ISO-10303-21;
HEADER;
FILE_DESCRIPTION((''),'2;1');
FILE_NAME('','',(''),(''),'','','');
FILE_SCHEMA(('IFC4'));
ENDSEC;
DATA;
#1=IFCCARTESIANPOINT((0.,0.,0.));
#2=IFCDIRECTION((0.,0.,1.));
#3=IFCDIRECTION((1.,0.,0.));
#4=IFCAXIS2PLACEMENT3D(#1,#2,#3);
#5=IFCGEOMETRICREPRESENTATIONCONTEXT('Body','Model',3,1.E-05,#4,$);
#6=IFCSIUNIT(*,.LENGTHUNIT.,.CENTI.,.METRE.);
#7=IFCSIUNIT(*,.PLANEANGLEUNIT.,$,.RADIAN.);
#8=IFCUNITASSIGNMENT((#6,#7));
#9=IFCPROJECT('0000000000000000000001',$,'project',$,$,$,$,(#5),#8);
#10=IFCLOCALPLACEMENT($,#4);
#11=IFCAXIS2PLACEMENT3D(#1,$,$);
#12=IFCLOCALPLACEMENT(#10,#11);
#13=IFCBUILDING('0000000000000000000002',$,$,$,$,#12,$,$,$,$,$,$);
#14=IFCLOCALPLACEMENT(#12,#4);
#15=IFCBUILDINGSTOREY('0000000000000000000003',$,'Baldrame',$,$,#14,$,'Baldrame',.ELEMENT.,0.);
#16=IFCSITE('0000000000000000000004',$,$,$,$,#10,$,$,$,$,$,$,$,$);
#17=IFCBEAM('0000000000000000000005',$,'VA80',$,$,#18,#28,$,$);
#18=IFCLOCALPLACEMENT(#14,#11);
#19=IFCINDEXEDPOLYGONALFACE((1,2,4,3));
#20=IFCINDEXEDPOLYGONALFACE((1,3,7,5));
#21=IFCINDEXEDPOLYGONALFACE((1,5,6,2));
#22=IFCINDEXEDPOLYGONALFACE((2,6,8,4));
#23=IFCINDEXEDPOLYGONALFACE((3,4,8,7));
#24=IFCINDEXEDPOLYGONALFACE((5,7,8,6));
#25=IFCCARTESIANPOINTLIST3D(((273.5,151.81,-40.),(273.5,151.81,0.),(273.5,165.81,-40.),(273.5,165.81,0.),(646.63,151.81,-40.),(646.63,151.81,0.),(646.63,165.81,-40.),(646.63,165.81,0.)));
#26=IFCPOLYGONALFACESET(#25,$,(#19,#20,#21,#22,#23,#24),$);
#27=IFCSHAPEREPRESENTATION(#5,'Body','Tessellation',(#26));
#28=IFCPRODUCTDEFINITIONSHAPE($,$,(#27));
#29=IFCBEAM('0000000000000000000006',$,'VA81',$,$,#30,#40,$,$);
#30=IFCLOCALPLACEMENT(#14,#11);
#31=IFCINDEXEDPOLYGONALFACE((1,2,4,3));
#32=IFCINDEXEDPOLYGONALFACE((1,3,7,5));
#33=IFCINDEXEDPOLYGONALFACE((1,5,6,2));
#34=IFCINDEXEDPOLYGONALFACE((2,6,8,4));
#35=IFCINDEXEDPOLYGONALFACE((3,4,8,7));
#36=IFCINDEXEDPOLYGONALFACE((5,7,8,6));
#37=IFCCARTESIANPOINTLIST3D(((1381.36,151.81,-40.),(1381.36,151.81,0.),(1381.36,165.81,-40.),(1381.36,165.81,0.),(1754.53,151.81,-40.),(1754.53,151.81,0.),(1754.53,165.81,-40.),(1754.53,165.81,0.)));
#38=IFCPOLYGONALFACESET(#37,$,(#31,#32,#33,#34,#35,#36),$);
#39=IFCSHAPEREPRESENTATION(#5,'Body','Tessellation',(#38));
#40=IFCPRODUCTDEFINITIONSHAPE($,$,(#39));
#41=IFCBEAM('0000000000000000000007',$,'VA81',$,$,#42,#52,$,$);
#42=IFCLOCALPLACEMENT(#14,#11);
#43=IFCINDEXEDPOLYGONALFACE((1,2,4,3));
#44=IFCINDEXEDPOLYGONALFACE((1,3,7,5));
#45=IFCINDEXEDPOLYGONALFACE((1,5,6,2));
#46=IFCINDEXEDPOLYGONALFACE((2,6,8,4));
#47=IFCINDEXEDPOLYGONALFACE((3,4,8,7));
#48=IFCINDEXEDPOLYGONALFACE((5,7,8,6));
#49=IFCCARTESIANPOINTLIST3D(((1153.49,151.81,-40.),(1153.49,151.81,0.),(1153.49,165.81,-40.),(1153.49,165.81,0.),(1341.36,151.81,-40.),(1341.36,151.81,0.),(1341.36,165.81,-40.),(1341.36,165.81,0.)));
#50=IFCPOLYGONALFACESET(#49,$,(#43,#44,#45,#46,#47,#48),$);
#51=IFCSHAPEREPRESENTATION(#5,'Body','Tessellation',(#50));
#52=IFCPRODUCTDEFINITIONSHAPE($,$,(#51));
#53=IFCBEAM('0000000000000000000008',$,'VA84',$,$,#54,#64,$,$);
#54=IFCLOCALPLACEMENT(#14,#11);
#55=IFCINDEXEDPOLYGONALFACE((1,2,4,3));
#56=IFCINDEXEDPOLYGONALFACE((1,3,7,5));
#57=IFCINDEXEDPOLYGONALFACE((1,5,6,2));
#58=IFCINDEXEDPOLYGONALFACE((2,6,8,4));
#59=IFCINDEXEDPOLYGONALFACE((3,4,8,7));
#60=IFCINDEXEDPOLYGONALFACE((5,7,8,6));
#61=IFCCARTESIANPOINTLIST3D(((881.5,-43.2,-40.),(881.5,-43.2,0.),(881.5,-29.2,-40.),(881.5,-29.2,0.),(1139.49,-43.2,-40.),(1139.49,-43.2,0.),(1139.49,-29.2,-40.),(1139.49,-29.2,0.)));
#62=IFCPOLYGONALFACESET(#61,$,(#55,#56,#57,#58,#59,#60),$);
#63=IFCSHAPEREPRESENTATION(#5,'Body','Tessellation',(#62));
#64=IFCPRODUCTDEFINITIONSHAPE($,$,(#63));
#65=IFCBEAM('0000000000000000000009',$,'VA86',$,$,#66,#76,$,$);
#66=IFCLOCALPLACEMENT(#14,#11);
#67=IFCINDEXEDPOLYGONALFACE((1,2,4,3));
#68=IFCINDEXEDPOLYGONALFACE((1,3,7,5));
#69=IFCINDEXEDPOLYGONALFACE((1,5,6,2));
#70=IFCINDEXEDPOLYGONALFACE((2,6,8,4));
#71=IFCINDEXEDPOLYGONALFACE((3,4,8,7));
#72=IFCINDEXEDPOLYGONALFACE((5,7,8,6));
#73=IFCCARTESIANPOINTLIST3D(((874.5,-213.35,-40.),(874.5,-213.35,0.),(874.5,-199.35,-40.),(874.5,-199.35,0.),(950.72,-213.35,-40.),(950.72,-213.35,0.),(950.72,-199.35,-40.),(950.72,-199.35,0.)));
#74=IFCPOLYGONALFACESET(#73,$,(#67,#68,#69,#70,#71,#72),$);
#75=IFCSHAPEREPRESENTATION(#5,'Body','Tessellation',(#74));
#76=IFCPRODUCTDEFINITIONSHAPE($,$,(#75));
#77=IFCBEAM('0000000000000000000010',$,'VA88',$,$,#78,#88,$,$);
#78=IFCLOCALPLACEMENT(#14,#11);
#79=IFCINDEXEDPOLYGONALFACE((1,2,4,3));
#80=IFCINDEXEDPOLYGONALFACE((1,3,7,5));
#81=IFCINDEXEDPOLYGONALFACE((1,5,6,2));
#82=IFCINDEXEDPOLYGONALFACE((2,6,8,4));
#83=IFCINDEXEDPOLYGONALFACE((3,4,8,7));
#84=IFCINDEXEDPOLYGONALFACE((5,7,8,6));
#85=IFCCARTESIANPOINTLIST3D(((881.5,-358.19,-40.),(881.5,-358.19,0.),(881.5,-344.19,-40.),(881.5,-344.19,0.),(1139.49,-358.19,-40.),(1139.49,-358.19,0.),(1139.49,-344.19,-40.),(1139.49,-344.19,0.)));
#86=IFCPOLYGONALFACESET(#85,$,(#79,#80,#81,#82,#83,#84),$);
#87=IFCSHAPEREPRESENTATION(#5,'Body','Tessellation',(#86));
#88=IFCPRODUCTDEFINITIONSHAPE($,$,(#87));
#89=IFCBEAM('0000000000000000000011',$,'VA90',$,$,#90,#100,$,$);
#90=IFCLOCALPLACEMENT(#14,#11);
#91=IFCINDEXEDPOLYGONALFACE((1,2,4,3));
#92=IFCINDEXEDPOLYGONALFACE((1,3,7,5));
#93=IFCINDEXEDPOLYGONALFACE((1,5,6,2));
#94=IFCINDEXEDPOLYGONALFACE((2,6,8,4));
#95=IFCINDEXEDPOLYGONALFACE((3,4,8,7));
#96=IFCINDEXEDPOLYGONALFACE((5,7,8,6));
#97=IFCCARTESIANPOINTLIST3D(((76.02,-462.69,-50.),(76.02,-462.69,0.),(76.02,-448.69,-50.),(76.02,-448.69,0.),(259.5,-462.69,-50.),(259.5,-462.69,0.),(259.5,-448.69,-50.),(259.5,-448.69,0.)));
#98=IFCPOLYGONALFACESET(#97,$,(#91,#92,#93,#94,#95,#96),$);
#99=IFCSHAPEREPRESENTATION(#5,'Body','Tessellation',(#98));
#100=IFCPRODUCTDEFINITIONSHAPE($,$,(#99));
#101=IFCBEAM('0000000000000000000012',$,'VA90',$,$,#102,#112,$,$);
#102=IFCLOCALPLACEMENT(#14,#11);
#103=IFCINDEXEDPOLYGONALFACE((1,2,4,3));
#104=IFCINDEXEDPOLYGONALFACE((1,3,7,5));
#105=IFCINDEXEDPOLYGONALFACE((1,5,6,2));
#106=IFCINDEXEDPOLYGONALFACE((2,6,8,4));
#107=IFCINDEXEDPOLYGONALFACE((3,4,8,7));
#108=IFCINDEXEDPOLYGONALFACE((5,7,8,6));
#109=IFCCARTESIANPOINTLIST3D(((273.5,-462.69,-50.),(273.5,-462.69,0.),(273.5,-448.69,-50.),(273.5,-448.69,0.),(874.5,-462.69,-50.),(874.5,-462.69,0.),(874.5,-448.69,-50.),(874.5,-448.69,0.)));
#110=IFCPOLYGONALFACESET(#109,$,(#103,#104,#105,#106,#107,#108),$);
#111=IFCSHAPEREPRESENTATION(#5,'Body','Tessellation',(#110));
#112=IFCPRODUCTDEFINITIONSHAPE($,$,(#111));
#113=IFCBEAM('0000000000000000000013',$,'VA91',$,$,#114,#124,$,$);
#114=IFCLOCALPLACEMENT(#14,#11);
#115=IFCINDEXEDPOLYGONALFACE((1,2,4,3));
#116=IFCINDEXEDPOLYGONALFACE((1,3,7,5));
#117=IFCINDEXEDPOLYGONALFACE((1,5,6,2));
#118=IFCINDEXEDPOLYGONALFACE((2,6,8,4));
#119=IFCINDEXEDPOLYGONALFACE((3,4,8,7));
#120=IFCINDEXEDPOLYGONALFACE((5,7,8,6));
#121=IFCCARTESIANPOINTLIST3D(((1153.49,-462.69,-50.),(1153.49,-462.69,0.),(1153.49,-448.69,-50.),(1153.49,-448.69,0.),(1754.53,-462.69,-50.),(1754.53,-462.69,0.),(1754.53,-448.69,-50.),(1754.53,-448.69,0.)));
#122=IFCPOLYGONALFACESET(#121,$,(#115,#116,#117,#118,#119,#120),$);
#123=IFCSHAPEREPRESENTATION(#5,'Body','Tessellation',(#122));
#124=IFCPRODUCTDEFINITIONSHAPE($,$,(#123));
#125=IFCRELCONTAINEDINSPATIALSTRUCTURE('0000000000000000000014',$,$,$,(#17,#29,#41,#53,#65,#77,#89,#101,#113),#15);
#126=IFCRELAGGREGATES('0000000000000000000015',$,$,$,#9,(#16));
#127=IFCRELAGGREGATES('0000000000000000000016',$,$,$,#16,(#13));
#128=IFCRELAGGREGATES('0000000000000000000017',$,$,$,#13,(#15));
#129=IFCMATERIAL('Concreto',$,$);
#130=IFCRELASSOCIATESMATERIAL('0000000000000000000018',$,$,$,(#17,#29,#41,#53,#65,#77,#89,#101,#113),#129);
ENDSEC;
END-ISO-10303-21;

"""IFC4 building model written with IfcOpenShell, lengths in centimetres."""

from ifc_helpers import new_model, si_unit, frame, origin, origin_with_axes, origin_2d_with_axis, place, context, project, spatial, rectangle, extrude, material, element, save


model = new_model("IFC4")

# Units and contexts
model_context = context("Model", 3, precision=1e-05, world=origin_with_axes(), identifier="Body")
ifc_project = project(units=[si_unit("LENGTHUNIT", "METRE", prefix="CENTI"), si_unit("PLANEANGLEUNIT", "RADIAN")], contexts=[model_context])

# Site, building, storey
site_placement = place(None, origin_with_axes())
site = spatial("IfcSite", under=ifc_project, at=site_placement)
building_placement = place(site_placement, origin())
building = spatial("IfcBuilding", under=site, at=building_placement)
storey_placement = place(building_placement, origin_with_axes())
storey = spatial("IfcBuildingStorey", under=building, at=storey_placement, Name="Baldrame", LongName="Baldrame", CompositionType="ELEMENT", Elevation=0.0)

# Shared definitions
ifc_material = material(Name="Concreto")

# Beams
beam_1_placement = place(storey_placement, frame((460.06, 158.81, 0.0), z_axis=(0.0, 0.0, 1.0), x_axis=(1.0, 0.0, 0.0)))
element("IfcBeam", 1, at=beam_1_placement, inside=storey, material=ifc_material, Name="VA80", context=model_context, shape_type="SolidModel", body=[
    extrude(rectangle(XDim=14.0, YDim=40.0, at=origin_2d_with_axis()), frame((-186.56, 0.0, -20.0), z_axis=(1.0, 0.0, 0.0), x_axis=(0.0, 1.0, 0.0)), (0.0, 0.0, 1.0), 373.13),
])
beam_2_placement = place(storey_placement, frame((1567.94, 158.81, 0.0), z_axis=(0.0, 0.0, 1.0), x_axis=(1.0, 0.0, 0.0)))
element("IfcBeam", 2, at=beam_2_placement, inside=storey, material=ifc_material, Name="VA81", context=model_context, shape_type="SolidModel", body=[
    extrude(rectangle(XDim=14.0, YDim=40.0, at=origin_2d_with_axis()), frame((-186.59, 0.0, -20.0), z_axis=(1.0, 0.0, 0.0), x_axis=(0.0, 1.0, 0.0)), (0.0, 0.0, 1.0), 373.17),
])
beam_3_placement = place(storey_placement, frame((1247.42, 158.81, 0.0), z_axis=(0.0, 0.0, 1.0), x_axis=(1.0, 0.0, 0.0)))
element("IfcBeam", 3, at=beam_3_placement, inside=storey, material=ifc_material, Name="VA81", context=model_context, shape_type="SolidModel", body=[
    extrude(rectangle(XDim=14.0, YDim=40.0, at=origin_2d_with_axis()), frame((-93.94, 0.0, -20.0), z_axis=(1.0, 0.0, 0.0), x_axis=(0.0, 1.0, 0.0)), (0.0, 0.0, 1.0), 187.87),
])
beam_4_placement = place(storey_placement, frame((1010.5, -36.2, 0.0), z_axis=(0.0, 0.0, 1.0), x_axis=(1.0, 0.0, 0.0)))
element("IfcBeam", 4, at=beam_4_placement, inside=storey, material=ifc_material, Name="VA84", context=model_context, shape_type="SolidModel", body=[
    extrude(rectangle(XDim=14.0, YDim=40.0, at=origin_2d_with_axis()), frame((-129.0, 0.0, -20.0), z_axis=(1.0, 0.0, 0.0), x_axis=(0.0, 1.0, 0.0)), (0.0, 0.0, 1.0), 257.99),
])
beam_5_placement = place(storey_placement, frame((912.61, -206.35, 0.0), z_axis=(0.0, 0.0, 1.0), x_axis=(1.0, 0.0, 0.0)))
element("IfcBeam", 5, at=beam_5_placement, inside=storey, material=ifc_material, Name="VA86", context=model_context, shape_type="SolidModel", body=[
    extrude(rectangle(XDim=14.0, YDim=40.0, at=origin_2d_with_axis()), frame((-38.11, 0.0, -20.0), z_axis=(1.0, 0.0, 0.0), x_axis=(0.0, 1.0, 0.0)), (0.0, 0.0, 1.0), 76.22),
])
beam_6_placement = place(storey_placement, frame((1010.5, -351.19, 0.0), z_axis=(0.0, 0.0, 1.0), x_axis=(1.0, 0.0, 0.0)))
element("IfcBeam", 6, at=beam_6_placement, inside=storey, material=ifc_material, Name="VA88", context=model_context, shape_type="SolidModel", body=[
    extrude(rectangle(XDim=14.0, YDim=40.0, at=origin_2d_with_axis()), frame((-129.0, 0.0, -20.0), z_axis=(1.0, 0.0, 0.0), x_axis=(0.0, 1.0, 0.0)), (0.0, 0.0, 1.0), 257.99),
])
beam_7_placement = place(storey_placement, frame((167.76, -455.69, 0.0), z_axis=(0.0, 0.0, 1.0), x_axis=(1.0, 0.0, 0.0)))
element("IfcBeam", 7, at=beam_7_placement, inside=storey, material=ifc_material, Name="VA90", context=model_context, shape_type="SolidModel", body=[
    extrude(rectangle(XDim=14.0, YDim=50.0, at=origin_2d_with_axis()), frame((-91.74, 0.0, -25.0), z_axis=(1.0, 0.0, 0.0), x_axis=(0.0, -1.0, 0.0)), (0.0, 0.0, 1.0), 183.48),
])
beam_8_placement = place(storey_placement, frame((574.0, -455.69, 0.0), z_axis=(0.0, 0.0, 1.0), x_axis=(1.0, 0.0, 0.0)))
element("IfcBeam", 8, at=beam_8_placement, inside=storey, material=ifc_material, Name="VA90", context=model_context, shape_type="SolidModel", body=[
    extrude(rectangle(XDim=14.0, YDim=50.0, at=origin_2d_with_axis()), frame((-300.5, 0.0, -25.0), z_axis=(1.0, 0.0, 0.0), x_axis=(0.0, -1.0, 0.0)), (0.0, 0.0, 1.0), 601.0),
])
beam_9_placement = place(storey_placement, frame((1454.01, -455.69, 0.0), z_axis=(0.0, 0.0, 1.0), x_axis=(1.0, 0.0, 0.0)))
element("IfcBeam", 9, at=beam_9_placement, inside=storey, material=ifc_material, Name="VA91", context=model_context, shape_type="SolidModel", body=[
    extrude(rectangle(XDim=14.0, YDim=50.0, at=origin_2d_with_axis()), frame((-300.52, 0.0, -25.0), z_axis=(1.0, 0.0, 0.0), x_axis=(0.0, 1.0, 0.0)), (0.0, 0.0, 1.0), 601.04),
])

save(model, "model.ifc")
